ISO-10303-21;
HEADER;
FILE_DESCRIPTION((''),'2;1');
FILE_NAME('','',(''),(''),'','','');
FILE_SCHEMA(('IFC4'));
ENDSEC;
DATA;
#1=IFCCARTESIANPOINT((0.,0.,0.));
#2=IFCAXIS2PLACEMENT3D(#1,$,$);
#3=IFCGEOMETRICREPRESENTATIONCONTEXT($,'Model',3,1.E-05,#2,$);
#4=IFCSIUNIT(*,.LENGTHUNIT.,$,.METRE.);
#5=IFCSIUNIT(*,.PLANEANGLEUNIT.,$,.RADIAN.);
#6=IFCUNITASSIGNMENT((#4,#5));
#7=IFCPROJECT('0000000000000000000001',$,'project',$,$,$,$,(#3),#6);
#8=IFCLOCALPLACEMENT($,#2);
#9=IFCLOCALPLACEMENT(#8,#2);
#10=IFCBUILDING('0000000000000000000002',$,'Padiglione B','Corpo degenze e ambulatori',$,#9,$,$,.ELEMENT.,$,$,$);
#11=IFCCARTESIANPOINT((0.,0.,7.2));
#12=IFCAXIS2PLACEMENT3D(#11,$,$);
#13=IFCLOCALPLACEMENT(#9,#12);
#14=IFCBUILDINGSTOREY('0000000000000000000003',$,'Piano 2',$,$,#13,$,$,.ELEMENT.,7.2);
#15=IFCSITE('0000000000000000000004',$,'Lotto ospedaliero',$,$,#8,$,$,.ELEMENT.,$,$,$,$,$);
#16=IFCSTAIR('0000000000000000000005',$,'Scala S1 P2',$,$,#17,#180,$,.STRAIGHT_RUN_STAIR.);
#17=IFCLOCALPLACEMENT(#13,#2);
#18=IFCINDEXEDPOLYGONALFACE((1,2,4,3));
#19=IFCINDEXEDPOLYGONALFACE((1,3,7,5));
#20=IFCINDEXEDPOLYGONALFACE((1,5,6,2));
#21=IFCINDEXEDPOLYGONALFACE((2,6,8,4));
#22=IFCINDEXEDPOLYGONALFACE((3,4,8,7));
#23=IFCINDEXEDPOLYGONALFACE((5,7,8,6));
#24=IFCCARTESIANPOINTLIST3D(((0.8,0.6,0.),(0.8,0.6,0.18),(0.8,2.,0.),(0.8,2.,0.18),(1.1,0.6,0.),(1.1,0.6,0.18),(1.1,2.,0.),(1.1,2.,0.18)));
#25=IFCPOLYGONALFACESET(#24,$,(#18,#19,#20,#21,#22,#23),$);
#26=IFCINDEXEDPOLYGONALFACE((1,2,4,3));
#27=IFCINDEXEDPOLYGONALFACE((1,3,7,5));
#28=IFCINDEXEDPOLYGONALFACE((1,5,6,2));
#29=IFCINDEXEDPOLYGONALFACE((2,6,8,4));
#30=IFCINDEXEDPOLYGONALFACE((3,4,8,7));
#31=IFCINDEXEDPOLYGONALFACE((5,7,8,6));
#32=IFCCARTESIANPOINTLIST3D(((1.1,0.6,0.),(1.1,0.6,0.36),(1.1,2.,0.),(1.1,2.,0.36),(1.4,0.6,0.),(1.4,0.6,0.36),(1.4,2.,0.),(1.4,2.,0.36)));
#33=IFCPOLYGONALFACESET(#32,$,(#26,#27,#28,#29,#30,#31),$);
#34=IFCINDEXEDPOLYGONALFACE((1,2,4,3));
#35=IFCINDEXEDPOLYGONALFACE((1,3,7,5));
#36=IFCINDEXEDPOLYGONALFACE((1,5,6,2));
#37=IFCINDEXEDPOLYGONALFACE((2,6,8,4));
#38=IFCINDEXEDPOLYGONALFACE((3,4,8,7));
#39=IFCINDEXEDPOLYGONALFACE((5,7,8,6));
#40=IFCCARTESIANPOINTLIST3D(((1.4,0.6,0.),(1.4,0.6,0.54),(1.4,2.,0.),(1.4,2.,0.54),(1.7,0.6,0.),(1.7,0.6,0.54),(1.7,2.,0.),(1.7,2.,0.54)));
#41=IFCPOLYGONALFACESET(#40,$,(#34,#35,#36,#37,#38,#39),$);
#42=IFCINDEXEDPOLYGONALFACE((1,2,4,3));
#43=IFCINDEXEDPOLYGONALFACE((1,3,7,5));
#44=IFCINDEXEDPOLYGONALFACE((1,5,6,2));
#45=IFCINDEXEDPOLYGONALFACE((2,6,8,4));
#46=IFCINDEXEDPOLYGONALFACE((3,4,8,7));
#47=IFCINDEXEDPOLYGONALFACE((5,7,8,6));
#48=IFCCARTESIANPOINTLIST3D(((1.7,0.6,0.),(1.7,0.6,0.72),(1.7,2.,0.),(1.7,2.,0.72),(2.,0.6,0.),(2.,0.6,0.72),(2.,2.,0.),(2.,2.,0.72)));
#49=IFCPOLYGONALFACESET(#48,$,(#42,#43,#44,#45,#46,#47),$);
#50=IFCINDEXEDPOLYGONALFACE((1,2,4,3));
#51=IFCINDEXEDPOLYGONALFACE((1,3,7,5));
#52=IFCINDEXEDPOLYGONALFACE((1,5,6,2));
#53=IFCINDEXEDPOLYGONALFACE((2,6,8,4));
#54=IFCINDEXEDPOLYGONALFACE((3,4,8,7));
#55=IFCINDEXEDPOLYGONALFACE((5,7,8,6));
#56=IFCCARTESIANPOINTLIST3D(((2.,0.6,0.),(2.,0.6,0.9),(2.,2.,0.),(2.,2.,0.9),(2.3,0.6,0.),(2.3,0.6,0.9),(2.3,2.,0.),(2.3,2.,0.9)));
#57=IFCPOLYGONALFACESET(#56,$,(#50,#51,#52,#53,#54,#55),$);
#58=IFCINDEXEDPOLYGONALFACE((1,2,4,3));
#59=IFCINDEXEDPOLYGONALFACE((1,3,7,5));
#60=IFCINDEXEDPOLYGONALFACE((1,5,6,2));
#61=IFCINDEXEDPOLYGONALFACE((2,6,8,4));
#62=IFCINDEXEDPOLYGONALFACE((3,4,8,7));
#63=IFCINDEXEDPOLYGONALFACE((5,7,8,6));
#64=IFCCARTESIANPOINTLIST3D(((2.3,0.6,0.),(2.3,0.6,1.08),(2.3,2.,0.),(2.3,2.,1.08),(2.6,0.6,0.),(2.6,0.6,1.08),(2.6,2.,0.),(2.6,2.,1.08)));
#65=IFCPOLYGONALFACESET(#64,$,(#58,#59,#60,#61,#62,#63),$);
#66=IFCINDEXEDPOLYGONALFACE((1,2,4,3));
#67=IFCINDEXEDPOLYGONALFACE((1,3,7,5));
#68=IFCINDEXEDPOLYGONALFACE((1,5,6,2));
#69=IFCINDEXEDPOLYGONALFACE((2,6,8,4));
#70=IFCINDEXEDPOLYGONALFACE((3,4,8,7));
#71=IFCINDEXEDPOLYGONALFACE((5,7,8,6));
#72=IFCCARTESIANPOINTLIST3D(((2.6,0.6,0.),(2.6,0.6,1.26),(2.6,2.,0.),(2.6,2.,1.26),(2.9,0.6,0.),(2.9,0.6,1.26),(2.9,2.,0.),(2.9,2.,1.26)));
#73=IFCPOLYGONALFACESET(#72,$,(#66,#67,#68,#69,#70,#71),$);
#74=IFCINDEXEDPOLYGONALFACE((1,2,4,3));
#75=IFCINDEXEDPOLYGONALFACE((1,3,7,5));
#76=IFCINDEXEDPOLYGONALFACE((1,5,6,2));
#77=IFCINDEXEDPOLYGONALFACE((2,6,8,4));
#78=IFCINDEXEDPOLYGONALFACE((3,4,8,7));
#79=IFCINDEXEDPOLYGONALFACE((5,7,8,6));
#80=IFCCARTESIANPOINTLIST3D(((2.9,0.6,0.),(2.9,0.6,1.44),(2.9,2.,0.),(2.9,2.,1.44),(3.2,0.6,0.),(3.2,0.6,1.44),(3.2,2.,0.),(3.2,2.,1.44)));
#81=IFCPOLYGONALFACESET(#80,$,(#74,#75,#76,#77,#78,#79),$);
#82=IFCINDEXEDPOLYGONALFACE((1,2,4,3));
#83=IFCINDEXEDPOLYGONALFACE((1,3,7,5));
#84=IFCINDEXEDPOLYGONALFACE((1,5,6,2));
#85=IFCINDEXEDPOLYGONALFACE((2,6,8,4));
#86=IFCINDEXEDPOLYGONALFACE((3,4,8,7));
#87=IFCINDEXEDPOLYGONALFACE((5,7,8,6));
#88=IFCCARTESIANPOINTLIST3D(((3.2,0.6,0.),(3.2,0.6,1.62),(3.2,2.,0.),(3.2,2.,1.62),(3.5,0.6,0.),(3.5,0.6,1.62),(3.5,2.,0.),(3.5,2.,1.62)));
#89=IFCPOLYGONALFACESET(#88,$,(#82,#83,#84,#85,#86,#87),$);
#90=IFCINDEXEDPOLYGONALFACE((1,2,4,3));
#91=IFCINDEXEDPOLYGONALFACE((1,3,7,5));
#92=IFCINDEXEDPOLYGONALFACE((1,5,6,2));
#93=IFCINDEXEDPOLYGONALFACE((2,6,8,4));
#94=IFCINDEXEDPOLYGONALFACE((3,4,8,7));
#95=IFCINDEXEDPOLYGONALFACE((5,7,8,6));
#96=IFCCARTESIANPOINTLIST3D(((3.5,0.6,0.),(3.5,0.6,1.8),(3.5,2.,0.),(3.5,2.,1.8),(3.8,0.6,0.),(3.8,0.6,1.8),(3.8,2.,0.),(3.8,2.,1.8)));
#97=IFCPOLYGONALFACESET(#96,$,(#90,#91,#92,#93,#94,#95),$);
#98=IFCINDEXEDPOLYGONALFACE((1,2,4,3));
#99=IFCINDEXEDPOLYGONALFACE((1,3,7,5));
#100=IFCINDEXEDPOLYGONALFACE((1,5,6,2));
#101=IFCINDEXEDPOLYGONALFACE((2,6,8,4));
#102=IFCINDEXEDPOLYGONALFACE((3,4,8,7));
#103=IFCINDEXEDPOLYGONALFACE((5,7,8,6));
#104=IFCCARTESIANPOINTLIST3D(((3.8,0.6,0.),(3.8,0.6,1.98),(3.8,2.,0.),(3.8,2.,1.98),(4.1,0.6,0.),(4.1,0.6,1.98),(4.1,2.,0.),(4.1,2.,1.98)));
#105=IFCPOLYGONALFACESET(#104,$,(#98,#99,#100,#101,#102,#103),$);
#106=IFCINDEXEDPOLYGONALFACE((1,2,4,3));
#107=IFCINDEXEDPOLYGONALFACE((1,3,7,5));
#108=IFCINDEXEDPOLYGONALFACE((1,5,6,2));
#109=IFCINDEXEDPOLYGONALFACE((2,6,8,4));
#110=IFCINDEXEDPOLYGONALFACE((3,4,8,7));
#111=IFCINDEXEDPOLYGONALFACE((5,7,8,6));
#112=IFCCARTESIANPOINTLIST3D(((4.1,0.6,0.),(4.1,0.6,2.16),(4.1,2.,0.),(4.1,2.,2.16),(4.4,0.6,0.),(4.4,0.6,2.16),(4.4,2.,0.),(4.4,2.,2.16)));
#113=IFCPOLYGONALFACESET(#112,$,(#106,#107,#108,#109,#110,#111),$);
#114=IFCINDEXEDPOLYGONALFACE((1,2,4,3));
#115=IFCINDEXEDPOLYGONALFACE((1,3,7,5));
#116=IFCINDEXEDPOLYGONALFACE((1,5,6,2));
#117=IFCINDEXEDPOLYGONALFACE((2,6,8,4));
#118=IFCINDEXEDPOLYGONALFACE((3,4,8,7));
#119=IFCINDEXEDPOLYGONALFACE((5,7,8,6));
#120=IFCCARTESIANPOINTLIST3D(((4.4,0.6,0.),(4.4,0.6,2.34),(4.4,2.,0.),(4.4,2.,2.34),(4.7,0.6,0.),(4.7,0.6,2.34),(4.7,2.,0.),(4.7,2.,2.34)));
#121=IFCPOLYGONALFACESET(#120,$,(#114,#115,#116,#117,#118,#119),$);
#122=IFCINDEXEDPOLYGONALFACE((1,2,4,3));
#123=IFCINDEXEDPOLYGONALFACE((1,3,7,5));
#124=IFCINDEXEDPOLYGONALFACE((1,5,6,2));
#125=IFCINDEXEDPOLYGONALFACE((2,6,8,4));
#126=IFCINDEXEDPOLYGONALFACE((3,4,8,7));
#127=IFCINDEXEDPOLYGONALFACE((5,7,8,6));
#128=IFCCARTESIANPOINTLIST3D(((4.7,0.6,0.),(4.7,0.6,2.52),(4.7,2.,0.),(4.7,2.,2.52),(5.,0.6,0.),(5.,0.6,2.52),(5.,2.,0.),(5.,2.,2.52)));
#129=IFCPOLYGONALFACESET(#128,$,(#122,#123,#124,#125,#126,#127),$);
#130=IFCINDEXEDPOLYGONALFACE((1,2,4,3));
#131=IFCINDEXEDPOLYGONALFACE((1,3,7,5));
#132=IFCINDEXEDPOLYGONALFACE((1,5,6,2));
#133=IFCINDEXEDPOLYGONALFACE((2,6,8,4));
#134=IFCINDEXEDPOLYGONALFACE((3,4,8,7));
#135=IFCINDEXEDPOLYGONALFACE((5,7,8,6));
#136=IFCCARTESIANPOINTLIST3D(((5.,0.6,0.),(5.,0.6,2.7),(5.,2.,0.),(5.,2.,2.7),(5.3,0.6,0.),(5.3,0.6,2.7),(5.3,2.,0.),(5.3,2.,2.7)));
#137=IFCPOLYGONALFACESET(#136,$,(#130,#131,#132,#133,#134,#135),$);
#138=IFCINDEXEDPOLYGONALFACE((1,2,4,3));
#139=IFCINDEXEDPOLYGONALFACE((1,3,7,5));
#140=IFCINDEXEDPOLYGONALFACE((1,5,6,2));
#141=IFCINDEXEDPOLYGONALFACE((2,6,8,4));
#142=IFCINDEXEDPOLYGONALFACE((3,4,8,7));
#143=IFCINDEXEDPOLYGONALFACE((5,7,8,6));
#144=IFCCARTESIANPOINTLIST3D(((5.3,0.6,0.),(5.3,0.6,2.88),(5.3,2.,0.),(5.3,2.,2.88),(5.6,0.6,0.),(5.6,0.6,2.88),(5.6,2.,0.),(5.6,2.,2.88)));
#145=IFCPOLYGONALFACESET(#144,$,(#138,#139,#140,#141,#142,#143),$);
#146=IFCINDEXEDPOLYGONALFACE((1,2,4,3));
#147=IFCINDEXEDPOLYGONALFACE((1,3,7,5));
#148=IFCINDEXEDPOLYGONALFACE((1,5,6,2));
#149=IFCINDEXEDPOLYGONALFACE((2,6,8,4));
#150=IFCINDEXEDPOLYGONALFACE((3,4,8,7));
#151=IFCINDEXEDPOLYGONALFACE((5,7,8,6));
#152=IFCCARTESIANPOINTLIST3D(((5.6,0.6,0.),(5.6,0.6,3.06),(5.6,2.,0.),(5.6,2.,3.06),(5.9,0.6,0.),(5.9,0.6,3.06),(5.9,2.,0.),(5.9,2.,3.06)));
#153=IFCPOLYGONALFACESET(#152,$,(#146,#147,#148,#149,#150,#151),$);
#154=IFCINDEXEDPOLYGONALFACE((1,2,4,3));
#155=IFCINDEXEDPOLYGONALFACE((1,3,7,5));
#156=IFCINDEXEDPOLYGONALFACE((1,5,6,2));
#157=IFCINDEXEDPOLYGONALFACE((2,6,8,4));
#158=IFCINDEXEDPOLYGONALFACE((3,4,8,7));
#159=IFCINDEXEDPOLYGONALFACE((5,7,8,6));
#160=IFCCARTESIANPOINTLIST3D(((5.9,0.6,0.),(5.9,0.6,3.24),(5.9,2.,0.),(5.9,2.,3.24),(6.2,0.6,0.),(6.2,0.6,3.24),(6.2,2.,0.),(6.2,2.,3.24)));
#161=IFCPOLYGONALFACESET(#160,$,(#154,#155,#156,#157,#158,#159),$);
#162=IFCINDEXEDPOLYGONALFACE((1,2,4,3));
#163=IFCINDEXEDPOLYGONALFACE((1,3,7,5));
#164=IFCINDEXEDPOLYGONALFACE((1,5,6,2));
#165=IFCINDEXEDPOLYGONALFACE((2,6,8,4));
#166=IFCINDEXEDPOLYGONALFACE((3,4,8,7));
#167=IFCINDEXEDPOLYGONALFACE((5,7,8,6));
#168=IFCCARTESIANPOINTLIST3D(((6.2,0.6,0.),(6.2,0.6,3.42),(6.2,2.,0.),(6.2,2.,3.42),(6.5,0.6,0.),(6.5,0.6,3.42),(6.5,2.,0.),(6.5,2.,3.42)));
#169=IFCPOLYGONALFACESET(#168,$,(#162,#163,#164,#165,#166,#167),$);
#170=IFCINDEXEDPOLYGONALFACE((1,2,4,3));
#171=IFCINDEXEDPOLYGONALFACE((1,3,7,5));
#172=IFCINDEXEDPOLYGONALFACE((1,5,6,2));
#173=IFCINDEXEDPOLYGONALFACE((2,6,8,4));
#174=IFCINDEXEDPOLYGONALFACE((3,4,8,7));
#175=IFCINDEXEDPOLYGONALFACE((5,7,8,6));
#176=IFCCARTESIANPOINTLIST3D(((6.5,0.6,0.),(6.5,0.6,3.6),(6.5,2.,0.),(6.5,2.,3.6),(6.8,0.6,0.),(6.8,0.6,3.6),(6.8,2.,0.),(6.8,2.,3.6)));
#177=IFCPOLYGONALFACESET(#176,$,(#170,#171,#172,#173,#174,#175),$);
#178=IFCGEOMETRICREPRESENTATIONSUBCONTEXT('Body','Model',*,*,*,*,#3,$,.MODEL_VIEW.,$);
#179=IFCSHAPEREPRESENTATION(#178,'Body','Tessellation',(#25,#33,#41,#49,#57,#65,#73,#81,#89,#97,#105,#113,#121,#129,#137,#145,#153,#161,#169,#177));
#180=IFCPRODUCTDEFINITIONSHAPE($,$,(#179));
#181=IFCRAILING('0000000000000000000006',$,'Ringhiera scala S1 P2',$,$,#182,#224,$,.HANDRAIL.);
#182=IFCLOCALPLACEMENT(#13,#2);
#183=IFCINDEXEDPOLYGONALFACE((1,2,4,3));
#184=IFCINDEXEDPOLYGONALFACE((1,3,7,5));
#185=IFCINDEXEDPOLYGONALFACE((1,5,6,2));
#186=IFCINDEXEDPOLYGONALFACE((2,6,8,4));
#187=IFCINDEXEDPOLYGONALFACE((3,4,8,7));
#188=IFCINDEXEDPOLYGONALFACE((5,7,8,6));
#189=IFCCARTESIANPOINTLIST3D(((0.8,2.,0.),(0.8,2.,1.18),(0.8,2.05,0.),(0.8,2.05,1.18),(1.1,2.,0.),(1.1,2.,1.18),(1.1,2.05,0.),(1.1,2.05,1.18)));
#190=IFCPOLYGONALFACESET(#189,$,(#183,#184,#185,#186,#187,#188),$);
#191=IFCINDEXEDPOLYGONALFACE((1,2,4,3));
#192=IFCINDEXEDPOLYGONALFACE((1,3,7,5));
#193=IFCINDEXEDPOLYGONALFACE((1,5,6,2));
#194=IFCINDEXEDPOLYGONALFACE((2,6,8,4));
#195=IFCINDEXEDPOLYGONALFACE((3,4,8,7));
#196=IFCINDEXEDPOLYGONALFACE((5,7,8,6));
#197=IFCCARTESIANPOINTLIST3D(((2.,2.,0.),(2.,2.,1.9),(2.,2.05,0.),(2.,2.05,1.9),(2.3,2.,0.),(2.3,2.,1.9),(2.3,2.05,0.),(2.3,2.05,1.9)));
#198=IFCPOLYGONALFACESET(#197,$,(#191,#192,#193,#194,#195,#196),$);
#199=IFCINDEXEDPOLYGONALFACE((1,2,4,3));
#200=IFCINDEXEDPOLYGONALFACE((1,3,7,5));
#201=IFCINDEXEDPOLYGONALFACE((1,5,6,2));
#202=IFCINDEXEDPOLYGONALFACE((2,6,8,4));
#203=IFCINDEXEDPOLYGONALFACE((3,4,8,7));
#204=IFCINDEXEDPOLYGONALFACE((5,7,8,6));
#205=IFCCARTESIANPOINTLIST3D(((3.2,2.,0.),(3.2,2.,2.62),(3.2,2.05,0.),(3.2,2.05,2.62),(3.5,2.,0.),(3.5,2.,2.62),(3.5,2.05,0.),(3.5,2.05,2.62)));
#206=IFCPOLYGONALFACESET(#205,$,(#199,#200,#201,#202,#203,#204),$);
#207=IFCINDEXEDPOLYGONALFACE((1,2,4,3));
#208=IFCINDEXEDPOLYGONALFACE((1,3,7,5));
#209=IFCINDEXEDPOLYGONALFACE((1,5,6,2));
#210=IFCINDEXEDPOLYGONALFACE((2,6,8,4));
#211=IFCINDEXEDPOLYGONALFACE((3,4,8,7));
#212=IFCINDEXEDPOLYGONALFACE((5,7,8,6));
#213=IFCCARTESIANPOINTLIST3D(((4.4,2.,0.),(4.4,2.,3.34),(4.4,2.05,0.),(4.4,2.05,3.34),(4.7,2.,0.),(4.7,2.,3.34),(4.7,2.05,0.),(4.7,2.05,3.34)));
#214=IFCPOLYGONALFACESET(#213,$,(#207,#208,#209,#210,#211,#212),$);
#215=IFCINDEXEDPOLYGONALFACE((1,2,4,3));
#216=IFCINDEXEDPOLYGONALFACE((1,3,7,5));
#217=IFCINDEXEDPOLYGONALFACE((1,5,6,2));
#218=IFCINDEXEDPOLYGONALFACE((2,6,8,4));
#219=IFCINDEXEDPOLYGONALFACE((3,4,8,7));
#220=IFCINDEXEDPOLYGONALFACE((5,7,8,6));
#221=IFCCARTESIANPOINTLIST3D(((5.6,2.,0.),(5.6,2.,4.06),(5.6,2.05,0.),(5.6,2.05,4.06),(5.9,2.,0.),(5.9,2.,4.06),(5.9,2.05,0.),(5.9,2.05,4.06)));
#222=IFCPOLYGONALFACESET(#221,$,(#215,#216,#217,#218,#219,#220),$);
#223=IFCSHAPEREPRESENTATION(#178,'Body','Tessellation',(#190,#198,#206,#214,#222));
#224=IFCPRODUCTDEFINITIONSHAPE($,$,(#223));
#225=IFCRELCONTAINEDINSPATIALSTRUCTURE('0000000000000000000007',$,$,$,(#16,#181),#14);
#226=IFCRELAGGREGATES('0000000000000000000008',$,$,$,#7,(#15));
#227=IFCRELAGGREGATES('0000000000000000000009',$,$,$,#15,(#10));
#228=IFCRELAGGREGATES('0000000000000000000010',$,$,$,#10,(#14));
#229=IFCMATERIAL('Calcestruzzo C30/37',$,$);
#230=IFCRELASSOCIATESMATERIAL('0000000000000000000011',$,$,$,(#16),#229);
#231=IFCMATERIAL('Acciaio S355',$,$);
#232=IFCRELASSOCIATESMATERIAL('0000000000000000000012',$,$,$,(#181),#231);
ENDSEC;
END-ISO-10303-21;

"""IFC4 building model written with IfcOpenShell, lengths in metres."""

from ifc_helpers import new_model, si_unit, frame, frame_2d, origin, place, context, subcontext, project, spatial, rectangle, extrude, material, element, save


model = new_model("IFC4")

# Units and contexts
model_context = context("Model", 3, precision=1e-05, world=origin())
body_context = subcontext(model_context, "Body", "Model", "MODEL_VIEW")
ifc_project = project(units=[si_unit("LENGTHUNIT", "METRE"), si_unit("PLANEANGLEUNIT", "RADIAN")], contexts=[model_context])

# Site, building, storey
site_placement = place(None, origin())
site = spatial("IfcSite", under=ifc_project, at=site_placement, Name="Lotto ospedaliero", CompositionType="ELEMENT")
building_placement = place(site_placement, origin())
building = spatial("IfcBuilding", under=site, at=building_placement, Name="Padiglione B", Description="Corpo degenze e ambulatori", CompositionType="ELEMENT")
storey_placement = place(building_placement, frame((0.0, 0.0, 7.2)))
storey = spatial("IfcBuildingStorey", under=building, at=storey_placement, Name="Piano 2", CompositionType="ELEMENT", Elevation=7.2)

# Shared definitions
ifc_material_1 = material(Name="Calcestruzzo C30/37")

# Stair
stair_placement = place(storey_placement, frame((0.8, 0.6, 0.0)))
element("IfcStair", 1, at=stair_placement, inside=storey, material=ifc_material_1, Name="Scala S1 P2", PredefinedType="STRAIGHT_RUN_STAIR", context=body_context, shape_type="SweptSolid", body=[
    extrude(rectangle(XDim=0.3, YDim=1.4, at=frame_2d((0.15, 0.7))), origin(), (0.0, 0.0, 1.0), 0.18),
    extrude(rectangle(XDim=0.3, YDim=1.4, at=frame_2d((0.15, 0.7))), frame((0.3, 0.0, 0.0)), (0.0, 0.0, 1.0), 0.36),
    extrude(rectangle(XDim=0.3, YDim=1.4, at=frame_2d((0.15, 0.7))), frame((0.6, 0.0, 0.0)), (0.0, 0.0, 1.0), 0.54),
    extrude(rectangle(XDim=0.3, YDim=1.4, at=frame_2d((0.15, 0.7))), frame((0.9, 0.0, 0.0)), (0.0, 0.0, 1.0), 0.72),
    extrude(rectangle(XDim=0.3, YDim=1.4, at=frame_2d((0.15, 0.7))), frame((1.2, 0.0, 0.0)), (0.0, 0.0, 1.0), 0.9),
    extrude(rectangle(XDim=0.3, YDim=1.4, at=frame_2d((0.15, 0.7))), frame((1.5, 0.0, 0.0)), (0.0, 0.0, 1.0), 1.08),
    extrude(rectangle(XDim=0.3, YDim=1.4, at=frame_2d((0.15, 0.7))), frame((1.8, 0.0, 0.0)), (0.0, 0.0, 1.0), 1.26),
    extrude(rectangle(XDim=0.3, YDim=1.4, at=frame_2d((0.15, 0.7))), frame((2.1, 0.0, 0.0)), (0.0, 0.0, 1.0), 1.44),
    extrude(rectangle(XDim=0.3, YDim=1.4, at=frame_2d((0.15, 0.7))), frame((2.4, 0.0, 0.0)), (0.0, 0.0, 1.0), 1.62),
    extrude(rectangle(XDim=0.3, YDim=1.4, at=frame_2d((0.15, 0.7))), frame((2.7, 0.0, 0.0)), (0.0, 0.0, 1.0), 1.8),
    extrude(rectangle(XDim=0.3, YDim=1.4, at=frame_2d((0.15, 0.7))), frame((3.0, 0.0, 0.0)), (0.0, 0.0, 1.0), 1.98),
    extrude(rectangle(XDim=0.3, YDim=1.4, at=frame_2d((0.15, 0.7))), frame((3.3, 0.0, 0.0)), (0.0, 0.0, 1.0), 2.16),
    extrude(rectangle(XDim=0.3, YDim=1.4, at=frame_2d((0.15, 0.7))), frame((3.6, 0.0, 0.0)), (0.0, 0.0, 1.0), 2.34),
    extrude(rectangle(XDim=0.3, YDim=1.4, at=frame_2d((0.15, 0.7))), frame((3.9, 0.0, 0.0)), (0.0, 0.0, 1.0), 2.52),
    extrude(rectangle(XDim=0.3, YDim=1.4, at=frame_2d((0.15, 0.7))), frame((4.2, 0.0, 0.0)), (0.0, 0.0, 1.0), 2.7),
    extrude(rectangle(XDim=0.3, YDim=1.4, at=frame_2d((0.15, 0.7))), frame((4.5, 0.0, 0.0)), (0.0, 0.0, 1.0), 2.88),
    extrude(rectangle(XDim=0.3, YDim=1.4, at=frame_2d((0.15, 0.7))), frame((4.8, 0.0, 0.0)), (0.0, 0.0, 1.0), 3.06),
    extrude(rectangle(XDim=0.3, YDim=1.4, at=frame_2d((0.15, 0.7))), frame((5.1, 0.0, 0.0)), (0.0, 0.0, 1.0), 3.24),
    extrude(rectangle(XDim=0.3, YDim=1.4, at=frame_2d((0.15, 0.7))), frame((5.4, 0.0, 0.0)), (0.0, 0.0, 1.0), 3.42),
    extrude(rectangle(XDim=0.3, YDim=1.4, at=frame_2d((0.15, 0.7))), frame((5.7, 0.0, 0.0)), (0.0, 0.0, 1.0), 3.6),
])

# Railing
ifc_material_2 = material(Name="Acciaio S355")
railing_placement = place(storey_placement, frame((0.8, 2.0, 0.0)))
element("IfcRailing", 2, at=railing_placement, inside=storey, material=ifc_material_2, Name="Ringhiera scala S1 P2", PredefinedType="HANDRAIL", context=body_context, shape_type="SweptSolid", body=[
    extrude(rectangle(XDim=0.3, YDim=0.05, at=frame_2d((0.15, 0.025))), origin(), (0.0, 0.0, 1.0), 1.18),
    extrude(rectangle(XDim=0.3, YDim=0.05, at=frame_2d((0.15, 0.025))), frame((1.2, 0.0, 0.0)), (0.0, 0.0, 1.0), 1.9),
    extrude(rectangle(XDim=0.3, YDim=0.05, at=frame_2d((0.15, 0.025))), frame((2.4, 0.0, 0.0)), (0.0, 0.0, 1.0), 2.62),
    extrude(rectangle(XDim=0.3, YDim=0.05, at=frame_2d((0.15, 0.025))), frame((3.6, 0.0, 0.0)), (0.0, 0.0, 1.0), 3.34),
    extrude(rectangle(XDim=0.3, YDim=0.05, at=frame_2d((0.15, 0.025))), frame((4.8, 0.0, 0.0)), (0.0, 0.0, 1.0), 4.06),
])

save(model, "model.ifc")
